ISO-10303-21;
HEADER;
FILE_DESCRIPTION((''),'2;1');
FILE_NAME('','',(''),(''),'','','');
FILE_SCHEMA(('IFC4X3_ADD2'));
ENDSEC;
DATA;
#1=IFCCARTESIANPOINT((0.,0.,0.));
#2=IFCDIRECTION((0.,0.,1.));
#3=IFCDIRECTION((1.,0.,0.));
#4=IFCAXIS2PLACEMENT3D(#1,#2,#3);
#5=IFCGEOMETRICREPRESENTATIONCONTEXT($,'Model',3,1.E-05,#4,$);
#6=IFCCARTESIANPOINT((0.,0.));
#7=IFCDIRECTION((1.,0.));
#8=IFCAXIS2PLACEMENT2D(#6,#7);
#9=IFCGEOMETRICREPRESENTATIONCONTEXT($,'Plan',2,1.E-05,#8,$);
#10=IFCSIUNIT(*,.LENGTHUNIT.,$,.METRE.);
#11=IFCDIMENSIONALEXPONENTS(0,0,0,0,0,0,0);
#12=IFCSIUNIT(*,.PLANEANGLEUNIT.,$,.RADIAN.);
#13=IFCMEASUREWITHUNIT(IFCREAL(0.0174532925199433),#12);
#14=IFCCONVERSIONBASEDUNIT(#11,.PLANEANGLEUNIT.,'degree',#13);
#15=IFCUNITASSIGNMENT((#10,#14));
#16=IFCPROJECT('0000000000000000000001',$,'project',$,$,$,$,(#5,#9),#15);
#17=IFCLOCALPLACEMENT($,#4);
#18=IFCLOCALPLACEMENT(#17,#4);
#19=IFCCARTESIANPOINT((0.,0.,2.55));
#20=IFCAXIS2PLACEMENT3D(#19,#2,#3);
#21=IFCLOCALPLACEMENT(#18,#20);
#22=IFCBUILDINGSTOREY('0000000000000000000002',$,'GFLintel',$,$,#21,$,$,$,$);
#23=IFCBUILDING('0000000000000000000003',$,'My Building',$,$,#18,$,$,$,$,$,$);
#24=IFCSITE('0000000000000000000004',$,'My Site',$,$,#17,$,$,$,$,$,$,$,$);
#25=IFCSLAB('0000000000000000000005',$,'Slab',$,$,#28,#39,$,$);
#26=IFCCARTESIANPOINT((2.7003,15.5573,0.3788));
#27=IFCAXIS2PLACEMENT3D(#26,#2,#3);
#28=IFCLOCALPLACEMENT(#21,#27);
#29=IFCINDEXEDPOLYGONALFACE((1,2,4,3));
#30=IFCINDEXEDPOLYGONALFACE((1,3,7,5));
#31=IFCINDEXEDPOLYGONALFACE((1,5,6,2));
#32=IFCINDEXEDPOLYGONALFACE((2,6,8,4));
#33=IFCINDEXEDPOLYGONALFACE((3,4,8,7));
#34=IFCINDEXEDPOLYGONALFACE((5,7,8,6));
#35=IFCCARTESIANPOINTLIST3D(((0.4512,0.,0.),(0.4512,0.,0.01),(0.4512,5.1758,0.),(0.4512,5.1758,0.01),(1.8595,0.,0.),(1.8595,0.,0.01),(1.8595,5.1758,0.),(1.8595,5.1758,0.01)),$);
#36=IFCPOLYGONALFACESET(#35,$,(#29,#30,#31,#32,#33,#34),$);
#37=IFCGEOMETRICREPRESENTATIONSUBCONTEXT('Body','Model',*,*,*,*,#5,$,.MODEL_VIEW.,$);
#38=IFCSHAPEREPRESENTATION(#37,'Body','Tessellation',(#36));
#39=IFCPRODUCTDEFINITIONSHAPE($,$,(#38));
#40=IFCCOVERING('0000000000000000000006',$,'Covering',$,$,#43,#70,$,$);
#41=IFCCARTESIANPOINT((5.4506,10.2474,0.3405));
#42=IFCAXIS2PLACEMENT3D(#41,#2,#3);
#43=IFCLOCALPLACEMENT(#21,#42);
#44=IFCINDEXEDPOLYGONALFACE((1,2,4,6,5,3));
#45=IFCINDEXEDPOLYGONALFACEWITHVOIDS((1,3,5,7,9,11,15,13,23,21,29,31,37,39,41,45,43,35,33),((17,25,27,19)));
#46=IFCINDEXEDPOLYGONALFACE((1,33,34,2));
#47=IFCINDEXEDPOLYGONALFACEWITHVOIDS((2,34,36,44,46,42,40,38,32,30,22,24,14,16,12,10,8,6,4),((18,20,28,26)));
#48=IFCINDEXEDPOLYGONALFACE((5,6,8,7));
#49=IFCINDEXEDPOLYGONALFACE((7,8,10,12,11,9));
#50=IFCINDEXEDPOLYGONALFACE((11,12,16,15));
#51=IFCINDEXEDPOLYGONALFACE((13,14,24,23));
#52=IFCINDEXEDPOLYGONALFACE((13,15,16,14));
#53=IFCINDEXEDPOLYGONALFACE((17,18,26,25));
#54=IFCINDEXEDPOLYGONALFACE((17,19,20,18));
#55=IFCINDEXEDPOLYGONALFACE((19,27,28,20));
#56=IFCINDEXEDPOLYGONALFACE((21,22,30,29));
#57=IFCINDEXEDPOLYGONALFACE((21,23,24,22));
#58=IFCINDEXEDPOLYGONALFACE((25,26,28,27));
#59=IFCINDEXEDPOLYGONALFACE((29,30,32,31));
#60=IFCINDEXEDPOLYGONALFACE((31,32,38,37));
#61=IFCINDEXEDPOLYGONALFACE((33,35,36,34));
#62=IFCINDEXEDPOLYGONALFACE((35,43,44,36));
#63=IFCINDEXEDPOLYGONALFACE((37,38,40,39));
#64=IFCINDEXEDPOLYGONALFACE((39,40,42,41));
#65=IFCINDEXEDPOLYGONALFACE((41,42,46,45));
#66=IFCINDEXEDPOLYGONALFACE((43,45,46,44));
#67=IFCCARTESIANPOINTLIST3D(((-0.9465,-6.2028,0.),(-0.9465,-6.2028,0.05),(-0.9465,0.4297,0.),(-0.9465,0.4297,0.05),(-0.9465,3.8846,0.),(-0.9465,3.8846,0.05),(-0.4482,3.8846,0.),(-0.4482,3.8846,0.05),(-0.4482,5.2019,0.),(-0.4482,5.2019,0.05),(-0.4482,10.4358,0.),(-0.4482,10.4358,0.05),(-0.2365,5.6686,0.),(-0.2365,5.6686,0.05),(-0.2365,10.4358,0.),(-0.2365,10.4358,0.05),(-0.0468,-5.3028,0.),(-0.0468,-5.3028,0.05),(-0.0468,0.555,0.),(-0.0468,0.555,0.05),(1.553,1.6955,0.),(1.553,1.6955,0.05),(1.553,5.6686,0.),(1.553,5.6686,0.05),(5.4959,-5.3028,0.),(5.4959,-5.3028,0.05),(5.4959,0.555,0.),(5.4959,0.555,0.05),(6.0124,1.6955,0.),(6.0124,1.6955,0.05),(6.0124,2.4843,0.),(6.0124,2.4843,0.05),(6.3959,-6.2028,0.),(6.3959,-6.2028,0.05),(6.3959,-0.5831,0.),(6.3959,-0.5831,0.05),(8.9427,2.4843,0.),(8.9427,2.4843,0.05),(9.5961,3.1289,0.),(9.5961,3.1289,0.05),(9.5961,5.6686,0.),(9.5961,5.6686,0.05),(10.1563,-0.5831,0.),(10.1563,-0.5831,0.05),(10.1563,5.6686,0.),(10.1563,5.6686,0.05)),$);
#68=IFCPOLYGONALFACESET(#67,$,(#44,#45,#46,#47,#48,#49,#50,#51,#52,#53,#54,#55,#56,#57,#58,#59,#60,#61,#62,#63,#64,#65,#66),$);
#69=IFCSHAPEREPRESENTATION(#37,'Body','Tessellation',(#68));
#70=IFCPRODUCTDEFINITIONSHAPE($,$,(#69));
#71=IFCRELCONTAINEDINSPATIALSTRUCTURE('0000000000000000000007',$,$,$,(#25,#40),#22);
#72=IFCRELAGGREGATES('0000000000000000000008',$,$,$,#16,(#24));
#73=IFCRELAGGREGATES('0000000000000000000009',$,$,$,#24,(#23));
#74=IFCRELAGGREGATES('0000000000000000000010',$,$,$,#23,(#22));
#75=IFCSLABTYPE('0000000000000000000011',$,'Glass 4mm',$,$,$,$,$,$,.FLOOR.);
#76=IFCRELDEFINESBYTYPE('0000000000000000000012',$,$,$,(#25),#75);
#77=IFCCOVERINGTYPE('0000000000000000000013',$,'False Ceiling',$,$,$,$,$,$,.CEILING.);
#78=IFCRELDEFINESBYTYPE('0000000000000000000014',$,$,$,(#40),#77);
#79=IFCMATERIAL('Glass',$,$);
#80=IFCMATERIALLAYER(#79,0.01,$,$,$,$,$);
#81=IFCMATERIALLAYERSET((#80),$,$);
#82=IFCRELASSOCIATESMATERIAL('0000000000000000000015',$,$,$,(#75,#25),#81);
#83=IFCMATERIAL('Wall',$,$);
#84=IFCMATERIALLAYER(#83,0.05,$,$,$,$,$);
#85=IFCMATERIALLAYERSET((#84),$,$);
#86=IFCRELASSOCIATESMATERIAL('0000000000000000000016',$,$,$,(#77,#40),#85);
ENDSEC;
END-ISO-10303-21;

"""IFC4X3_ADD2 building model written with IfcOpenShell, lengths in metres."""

from ifc_helpers import new_model, entity, si_unit, converted_unit, frame, origin_with_axes, origin_2d_with_axis, place, context, subcontext, project, spatial, line, indexed_curve, outline, extrude, material, layer, layer_set, layer_usage, type_object, element, save


model = new_model("IFC4X3_ADD2")

# Units and contexts
model_context = context("Model", 3, precision=1e-05, world=origin_with_axes())
plan_context = context("Plan", 2, precision=1e-05, world=origin_2d_with_axis())
body_context = subcontext(model_context, "Body", "Model", "MODEL_VIEW")
ifc_project = project(units=[si_unit("LENGTHUNIT", "METRE"), converted_unit("PLANEANGLEUNIT", "degree", entity("IfcReal", 0.0174532925199433), si_unit("PLANEANGLEUNIT", "RADIAN"), dimensions=[0, 0, 0, 0, 0, 0, 0])], contexts=[model_context, plan_context])

# Site, building, storey
site_placement = place(None, origin_with_axes())
site = spatial("IfcSite", under=ifc_project, at=site_placement, Name="My Site")
building_placement = place(site_placement, origin_with_axes())
building = spatial("IfcBuilding", under=site, at=building_placement, Name="My Building")
storey_placement = place(building_placement, frame((0.0, 0.0, 2.55), z_axis=(0.0, 0.0, 1.0), x_axis=(1.0, 0.0, 0.0)))
storey = spatial("IfcBuildingStorey", under=building, at=storey_placement, Name="GFLintel")

# Shared definitions
ifc_material_1 = material(Name="Wall")

# Slab
ifc_material_2 = material(Name="Glass")
ifc_layer_1 = layer(ifc_material_2, 0.01)
ifc_layer_set_1 = layer_set([ifc_layer_1])
ifc_layer_usage_1 = layer_usage(ifc_layer_set_1, "AXIS3", "POSITIVE", 0.0)
slab_type = type_object("IfcSlabType", Name="Glass 4mm", PredefinedType="FLOOR", material=ifc_layer_set_1)
slab_placement = place(storey_placement, frame((2.7003, 15.5573, 0.3788), z_axis=(0.0, 0.0, 1.0), x_axis=(1.0, 0.0, 0.0)))
element("IfcSlab", 1, at=slab_placement, inside=storey, type_object=slab_type, material=ifc_layer_usage_1, Name="Slab", context=body_context, shape_type="SweptSolid", body=[
    extrude(outline(indexed_curve([(1.8595, 5.1758), (1.8595, 0.0), (0.4512, 0.0), (0.4512, 5.1758)], segments=[line(3, 2), line(2, 1), line(1, 4), line(4, 3)], self_intersect=False)), None, (0.0, 0.0, 1.0), 0.01),
])

# Covering
ifc_layer_2 = layer(ifc_material_1, 0.05)
ifc_layer_set_2 = layer_set([ifc_layer_2])
ifc_layer_usage_2 = layer_usage(ifc_layer_set_2, "AXIS3", "POSITIVE", 0.0)
covering_type = type_object("IfcCoveringType", Name="False Ceiling", PredefinedType="CEILING", material=ifc_layer_set_2)
covering_placement = place(storey_placement, frame((5.4506, 10.2474, 0.3405), z_axis=(0.0, 0.0, 1.0), x_axis=(1.0, 0.0, 0.0)))
element("IfcCovering", 2, at=covering_placement, inside=storey, type_object=covering_type, material=ifc_layer_usage_2, Name="Covering", context=body_context, shape_type="SweptSolid", body=[
    extrude(outline(indexed_curve([(-0.4482, 5.2019), (-0.4482, 3.8846), (-0.9465, 3.8846), (-0.9465, 0.4297), (-0.9465, -6.2028), (6.3959, -6.2028), (6.3959, -0.5831), (10.1563, -0.5831), (10.1563, 5.6686), (9.5961, 5.6686), (9.5961, 3.1289), (8.9427, 2.4843), (6.0124, 2.4843), (6.0124, 1.6955), (1.553, 1.6955), (1.553, 5.6686), (-0.2365, 5.6686), (-0.2365, 10.4358), (-0.4482, 10.4358), (-0.4482, 5.2019)]), holes=[indexed_curve([(5.4959, -5.3028), (5.4959, 0.555), (-0.0468, 0.555), (-0.0468, -5.3028), (5.4959, -5.3028)])]), None, (0.0, 0.0, 1.0), 0.05),
])

save(model, "model.ifc")
